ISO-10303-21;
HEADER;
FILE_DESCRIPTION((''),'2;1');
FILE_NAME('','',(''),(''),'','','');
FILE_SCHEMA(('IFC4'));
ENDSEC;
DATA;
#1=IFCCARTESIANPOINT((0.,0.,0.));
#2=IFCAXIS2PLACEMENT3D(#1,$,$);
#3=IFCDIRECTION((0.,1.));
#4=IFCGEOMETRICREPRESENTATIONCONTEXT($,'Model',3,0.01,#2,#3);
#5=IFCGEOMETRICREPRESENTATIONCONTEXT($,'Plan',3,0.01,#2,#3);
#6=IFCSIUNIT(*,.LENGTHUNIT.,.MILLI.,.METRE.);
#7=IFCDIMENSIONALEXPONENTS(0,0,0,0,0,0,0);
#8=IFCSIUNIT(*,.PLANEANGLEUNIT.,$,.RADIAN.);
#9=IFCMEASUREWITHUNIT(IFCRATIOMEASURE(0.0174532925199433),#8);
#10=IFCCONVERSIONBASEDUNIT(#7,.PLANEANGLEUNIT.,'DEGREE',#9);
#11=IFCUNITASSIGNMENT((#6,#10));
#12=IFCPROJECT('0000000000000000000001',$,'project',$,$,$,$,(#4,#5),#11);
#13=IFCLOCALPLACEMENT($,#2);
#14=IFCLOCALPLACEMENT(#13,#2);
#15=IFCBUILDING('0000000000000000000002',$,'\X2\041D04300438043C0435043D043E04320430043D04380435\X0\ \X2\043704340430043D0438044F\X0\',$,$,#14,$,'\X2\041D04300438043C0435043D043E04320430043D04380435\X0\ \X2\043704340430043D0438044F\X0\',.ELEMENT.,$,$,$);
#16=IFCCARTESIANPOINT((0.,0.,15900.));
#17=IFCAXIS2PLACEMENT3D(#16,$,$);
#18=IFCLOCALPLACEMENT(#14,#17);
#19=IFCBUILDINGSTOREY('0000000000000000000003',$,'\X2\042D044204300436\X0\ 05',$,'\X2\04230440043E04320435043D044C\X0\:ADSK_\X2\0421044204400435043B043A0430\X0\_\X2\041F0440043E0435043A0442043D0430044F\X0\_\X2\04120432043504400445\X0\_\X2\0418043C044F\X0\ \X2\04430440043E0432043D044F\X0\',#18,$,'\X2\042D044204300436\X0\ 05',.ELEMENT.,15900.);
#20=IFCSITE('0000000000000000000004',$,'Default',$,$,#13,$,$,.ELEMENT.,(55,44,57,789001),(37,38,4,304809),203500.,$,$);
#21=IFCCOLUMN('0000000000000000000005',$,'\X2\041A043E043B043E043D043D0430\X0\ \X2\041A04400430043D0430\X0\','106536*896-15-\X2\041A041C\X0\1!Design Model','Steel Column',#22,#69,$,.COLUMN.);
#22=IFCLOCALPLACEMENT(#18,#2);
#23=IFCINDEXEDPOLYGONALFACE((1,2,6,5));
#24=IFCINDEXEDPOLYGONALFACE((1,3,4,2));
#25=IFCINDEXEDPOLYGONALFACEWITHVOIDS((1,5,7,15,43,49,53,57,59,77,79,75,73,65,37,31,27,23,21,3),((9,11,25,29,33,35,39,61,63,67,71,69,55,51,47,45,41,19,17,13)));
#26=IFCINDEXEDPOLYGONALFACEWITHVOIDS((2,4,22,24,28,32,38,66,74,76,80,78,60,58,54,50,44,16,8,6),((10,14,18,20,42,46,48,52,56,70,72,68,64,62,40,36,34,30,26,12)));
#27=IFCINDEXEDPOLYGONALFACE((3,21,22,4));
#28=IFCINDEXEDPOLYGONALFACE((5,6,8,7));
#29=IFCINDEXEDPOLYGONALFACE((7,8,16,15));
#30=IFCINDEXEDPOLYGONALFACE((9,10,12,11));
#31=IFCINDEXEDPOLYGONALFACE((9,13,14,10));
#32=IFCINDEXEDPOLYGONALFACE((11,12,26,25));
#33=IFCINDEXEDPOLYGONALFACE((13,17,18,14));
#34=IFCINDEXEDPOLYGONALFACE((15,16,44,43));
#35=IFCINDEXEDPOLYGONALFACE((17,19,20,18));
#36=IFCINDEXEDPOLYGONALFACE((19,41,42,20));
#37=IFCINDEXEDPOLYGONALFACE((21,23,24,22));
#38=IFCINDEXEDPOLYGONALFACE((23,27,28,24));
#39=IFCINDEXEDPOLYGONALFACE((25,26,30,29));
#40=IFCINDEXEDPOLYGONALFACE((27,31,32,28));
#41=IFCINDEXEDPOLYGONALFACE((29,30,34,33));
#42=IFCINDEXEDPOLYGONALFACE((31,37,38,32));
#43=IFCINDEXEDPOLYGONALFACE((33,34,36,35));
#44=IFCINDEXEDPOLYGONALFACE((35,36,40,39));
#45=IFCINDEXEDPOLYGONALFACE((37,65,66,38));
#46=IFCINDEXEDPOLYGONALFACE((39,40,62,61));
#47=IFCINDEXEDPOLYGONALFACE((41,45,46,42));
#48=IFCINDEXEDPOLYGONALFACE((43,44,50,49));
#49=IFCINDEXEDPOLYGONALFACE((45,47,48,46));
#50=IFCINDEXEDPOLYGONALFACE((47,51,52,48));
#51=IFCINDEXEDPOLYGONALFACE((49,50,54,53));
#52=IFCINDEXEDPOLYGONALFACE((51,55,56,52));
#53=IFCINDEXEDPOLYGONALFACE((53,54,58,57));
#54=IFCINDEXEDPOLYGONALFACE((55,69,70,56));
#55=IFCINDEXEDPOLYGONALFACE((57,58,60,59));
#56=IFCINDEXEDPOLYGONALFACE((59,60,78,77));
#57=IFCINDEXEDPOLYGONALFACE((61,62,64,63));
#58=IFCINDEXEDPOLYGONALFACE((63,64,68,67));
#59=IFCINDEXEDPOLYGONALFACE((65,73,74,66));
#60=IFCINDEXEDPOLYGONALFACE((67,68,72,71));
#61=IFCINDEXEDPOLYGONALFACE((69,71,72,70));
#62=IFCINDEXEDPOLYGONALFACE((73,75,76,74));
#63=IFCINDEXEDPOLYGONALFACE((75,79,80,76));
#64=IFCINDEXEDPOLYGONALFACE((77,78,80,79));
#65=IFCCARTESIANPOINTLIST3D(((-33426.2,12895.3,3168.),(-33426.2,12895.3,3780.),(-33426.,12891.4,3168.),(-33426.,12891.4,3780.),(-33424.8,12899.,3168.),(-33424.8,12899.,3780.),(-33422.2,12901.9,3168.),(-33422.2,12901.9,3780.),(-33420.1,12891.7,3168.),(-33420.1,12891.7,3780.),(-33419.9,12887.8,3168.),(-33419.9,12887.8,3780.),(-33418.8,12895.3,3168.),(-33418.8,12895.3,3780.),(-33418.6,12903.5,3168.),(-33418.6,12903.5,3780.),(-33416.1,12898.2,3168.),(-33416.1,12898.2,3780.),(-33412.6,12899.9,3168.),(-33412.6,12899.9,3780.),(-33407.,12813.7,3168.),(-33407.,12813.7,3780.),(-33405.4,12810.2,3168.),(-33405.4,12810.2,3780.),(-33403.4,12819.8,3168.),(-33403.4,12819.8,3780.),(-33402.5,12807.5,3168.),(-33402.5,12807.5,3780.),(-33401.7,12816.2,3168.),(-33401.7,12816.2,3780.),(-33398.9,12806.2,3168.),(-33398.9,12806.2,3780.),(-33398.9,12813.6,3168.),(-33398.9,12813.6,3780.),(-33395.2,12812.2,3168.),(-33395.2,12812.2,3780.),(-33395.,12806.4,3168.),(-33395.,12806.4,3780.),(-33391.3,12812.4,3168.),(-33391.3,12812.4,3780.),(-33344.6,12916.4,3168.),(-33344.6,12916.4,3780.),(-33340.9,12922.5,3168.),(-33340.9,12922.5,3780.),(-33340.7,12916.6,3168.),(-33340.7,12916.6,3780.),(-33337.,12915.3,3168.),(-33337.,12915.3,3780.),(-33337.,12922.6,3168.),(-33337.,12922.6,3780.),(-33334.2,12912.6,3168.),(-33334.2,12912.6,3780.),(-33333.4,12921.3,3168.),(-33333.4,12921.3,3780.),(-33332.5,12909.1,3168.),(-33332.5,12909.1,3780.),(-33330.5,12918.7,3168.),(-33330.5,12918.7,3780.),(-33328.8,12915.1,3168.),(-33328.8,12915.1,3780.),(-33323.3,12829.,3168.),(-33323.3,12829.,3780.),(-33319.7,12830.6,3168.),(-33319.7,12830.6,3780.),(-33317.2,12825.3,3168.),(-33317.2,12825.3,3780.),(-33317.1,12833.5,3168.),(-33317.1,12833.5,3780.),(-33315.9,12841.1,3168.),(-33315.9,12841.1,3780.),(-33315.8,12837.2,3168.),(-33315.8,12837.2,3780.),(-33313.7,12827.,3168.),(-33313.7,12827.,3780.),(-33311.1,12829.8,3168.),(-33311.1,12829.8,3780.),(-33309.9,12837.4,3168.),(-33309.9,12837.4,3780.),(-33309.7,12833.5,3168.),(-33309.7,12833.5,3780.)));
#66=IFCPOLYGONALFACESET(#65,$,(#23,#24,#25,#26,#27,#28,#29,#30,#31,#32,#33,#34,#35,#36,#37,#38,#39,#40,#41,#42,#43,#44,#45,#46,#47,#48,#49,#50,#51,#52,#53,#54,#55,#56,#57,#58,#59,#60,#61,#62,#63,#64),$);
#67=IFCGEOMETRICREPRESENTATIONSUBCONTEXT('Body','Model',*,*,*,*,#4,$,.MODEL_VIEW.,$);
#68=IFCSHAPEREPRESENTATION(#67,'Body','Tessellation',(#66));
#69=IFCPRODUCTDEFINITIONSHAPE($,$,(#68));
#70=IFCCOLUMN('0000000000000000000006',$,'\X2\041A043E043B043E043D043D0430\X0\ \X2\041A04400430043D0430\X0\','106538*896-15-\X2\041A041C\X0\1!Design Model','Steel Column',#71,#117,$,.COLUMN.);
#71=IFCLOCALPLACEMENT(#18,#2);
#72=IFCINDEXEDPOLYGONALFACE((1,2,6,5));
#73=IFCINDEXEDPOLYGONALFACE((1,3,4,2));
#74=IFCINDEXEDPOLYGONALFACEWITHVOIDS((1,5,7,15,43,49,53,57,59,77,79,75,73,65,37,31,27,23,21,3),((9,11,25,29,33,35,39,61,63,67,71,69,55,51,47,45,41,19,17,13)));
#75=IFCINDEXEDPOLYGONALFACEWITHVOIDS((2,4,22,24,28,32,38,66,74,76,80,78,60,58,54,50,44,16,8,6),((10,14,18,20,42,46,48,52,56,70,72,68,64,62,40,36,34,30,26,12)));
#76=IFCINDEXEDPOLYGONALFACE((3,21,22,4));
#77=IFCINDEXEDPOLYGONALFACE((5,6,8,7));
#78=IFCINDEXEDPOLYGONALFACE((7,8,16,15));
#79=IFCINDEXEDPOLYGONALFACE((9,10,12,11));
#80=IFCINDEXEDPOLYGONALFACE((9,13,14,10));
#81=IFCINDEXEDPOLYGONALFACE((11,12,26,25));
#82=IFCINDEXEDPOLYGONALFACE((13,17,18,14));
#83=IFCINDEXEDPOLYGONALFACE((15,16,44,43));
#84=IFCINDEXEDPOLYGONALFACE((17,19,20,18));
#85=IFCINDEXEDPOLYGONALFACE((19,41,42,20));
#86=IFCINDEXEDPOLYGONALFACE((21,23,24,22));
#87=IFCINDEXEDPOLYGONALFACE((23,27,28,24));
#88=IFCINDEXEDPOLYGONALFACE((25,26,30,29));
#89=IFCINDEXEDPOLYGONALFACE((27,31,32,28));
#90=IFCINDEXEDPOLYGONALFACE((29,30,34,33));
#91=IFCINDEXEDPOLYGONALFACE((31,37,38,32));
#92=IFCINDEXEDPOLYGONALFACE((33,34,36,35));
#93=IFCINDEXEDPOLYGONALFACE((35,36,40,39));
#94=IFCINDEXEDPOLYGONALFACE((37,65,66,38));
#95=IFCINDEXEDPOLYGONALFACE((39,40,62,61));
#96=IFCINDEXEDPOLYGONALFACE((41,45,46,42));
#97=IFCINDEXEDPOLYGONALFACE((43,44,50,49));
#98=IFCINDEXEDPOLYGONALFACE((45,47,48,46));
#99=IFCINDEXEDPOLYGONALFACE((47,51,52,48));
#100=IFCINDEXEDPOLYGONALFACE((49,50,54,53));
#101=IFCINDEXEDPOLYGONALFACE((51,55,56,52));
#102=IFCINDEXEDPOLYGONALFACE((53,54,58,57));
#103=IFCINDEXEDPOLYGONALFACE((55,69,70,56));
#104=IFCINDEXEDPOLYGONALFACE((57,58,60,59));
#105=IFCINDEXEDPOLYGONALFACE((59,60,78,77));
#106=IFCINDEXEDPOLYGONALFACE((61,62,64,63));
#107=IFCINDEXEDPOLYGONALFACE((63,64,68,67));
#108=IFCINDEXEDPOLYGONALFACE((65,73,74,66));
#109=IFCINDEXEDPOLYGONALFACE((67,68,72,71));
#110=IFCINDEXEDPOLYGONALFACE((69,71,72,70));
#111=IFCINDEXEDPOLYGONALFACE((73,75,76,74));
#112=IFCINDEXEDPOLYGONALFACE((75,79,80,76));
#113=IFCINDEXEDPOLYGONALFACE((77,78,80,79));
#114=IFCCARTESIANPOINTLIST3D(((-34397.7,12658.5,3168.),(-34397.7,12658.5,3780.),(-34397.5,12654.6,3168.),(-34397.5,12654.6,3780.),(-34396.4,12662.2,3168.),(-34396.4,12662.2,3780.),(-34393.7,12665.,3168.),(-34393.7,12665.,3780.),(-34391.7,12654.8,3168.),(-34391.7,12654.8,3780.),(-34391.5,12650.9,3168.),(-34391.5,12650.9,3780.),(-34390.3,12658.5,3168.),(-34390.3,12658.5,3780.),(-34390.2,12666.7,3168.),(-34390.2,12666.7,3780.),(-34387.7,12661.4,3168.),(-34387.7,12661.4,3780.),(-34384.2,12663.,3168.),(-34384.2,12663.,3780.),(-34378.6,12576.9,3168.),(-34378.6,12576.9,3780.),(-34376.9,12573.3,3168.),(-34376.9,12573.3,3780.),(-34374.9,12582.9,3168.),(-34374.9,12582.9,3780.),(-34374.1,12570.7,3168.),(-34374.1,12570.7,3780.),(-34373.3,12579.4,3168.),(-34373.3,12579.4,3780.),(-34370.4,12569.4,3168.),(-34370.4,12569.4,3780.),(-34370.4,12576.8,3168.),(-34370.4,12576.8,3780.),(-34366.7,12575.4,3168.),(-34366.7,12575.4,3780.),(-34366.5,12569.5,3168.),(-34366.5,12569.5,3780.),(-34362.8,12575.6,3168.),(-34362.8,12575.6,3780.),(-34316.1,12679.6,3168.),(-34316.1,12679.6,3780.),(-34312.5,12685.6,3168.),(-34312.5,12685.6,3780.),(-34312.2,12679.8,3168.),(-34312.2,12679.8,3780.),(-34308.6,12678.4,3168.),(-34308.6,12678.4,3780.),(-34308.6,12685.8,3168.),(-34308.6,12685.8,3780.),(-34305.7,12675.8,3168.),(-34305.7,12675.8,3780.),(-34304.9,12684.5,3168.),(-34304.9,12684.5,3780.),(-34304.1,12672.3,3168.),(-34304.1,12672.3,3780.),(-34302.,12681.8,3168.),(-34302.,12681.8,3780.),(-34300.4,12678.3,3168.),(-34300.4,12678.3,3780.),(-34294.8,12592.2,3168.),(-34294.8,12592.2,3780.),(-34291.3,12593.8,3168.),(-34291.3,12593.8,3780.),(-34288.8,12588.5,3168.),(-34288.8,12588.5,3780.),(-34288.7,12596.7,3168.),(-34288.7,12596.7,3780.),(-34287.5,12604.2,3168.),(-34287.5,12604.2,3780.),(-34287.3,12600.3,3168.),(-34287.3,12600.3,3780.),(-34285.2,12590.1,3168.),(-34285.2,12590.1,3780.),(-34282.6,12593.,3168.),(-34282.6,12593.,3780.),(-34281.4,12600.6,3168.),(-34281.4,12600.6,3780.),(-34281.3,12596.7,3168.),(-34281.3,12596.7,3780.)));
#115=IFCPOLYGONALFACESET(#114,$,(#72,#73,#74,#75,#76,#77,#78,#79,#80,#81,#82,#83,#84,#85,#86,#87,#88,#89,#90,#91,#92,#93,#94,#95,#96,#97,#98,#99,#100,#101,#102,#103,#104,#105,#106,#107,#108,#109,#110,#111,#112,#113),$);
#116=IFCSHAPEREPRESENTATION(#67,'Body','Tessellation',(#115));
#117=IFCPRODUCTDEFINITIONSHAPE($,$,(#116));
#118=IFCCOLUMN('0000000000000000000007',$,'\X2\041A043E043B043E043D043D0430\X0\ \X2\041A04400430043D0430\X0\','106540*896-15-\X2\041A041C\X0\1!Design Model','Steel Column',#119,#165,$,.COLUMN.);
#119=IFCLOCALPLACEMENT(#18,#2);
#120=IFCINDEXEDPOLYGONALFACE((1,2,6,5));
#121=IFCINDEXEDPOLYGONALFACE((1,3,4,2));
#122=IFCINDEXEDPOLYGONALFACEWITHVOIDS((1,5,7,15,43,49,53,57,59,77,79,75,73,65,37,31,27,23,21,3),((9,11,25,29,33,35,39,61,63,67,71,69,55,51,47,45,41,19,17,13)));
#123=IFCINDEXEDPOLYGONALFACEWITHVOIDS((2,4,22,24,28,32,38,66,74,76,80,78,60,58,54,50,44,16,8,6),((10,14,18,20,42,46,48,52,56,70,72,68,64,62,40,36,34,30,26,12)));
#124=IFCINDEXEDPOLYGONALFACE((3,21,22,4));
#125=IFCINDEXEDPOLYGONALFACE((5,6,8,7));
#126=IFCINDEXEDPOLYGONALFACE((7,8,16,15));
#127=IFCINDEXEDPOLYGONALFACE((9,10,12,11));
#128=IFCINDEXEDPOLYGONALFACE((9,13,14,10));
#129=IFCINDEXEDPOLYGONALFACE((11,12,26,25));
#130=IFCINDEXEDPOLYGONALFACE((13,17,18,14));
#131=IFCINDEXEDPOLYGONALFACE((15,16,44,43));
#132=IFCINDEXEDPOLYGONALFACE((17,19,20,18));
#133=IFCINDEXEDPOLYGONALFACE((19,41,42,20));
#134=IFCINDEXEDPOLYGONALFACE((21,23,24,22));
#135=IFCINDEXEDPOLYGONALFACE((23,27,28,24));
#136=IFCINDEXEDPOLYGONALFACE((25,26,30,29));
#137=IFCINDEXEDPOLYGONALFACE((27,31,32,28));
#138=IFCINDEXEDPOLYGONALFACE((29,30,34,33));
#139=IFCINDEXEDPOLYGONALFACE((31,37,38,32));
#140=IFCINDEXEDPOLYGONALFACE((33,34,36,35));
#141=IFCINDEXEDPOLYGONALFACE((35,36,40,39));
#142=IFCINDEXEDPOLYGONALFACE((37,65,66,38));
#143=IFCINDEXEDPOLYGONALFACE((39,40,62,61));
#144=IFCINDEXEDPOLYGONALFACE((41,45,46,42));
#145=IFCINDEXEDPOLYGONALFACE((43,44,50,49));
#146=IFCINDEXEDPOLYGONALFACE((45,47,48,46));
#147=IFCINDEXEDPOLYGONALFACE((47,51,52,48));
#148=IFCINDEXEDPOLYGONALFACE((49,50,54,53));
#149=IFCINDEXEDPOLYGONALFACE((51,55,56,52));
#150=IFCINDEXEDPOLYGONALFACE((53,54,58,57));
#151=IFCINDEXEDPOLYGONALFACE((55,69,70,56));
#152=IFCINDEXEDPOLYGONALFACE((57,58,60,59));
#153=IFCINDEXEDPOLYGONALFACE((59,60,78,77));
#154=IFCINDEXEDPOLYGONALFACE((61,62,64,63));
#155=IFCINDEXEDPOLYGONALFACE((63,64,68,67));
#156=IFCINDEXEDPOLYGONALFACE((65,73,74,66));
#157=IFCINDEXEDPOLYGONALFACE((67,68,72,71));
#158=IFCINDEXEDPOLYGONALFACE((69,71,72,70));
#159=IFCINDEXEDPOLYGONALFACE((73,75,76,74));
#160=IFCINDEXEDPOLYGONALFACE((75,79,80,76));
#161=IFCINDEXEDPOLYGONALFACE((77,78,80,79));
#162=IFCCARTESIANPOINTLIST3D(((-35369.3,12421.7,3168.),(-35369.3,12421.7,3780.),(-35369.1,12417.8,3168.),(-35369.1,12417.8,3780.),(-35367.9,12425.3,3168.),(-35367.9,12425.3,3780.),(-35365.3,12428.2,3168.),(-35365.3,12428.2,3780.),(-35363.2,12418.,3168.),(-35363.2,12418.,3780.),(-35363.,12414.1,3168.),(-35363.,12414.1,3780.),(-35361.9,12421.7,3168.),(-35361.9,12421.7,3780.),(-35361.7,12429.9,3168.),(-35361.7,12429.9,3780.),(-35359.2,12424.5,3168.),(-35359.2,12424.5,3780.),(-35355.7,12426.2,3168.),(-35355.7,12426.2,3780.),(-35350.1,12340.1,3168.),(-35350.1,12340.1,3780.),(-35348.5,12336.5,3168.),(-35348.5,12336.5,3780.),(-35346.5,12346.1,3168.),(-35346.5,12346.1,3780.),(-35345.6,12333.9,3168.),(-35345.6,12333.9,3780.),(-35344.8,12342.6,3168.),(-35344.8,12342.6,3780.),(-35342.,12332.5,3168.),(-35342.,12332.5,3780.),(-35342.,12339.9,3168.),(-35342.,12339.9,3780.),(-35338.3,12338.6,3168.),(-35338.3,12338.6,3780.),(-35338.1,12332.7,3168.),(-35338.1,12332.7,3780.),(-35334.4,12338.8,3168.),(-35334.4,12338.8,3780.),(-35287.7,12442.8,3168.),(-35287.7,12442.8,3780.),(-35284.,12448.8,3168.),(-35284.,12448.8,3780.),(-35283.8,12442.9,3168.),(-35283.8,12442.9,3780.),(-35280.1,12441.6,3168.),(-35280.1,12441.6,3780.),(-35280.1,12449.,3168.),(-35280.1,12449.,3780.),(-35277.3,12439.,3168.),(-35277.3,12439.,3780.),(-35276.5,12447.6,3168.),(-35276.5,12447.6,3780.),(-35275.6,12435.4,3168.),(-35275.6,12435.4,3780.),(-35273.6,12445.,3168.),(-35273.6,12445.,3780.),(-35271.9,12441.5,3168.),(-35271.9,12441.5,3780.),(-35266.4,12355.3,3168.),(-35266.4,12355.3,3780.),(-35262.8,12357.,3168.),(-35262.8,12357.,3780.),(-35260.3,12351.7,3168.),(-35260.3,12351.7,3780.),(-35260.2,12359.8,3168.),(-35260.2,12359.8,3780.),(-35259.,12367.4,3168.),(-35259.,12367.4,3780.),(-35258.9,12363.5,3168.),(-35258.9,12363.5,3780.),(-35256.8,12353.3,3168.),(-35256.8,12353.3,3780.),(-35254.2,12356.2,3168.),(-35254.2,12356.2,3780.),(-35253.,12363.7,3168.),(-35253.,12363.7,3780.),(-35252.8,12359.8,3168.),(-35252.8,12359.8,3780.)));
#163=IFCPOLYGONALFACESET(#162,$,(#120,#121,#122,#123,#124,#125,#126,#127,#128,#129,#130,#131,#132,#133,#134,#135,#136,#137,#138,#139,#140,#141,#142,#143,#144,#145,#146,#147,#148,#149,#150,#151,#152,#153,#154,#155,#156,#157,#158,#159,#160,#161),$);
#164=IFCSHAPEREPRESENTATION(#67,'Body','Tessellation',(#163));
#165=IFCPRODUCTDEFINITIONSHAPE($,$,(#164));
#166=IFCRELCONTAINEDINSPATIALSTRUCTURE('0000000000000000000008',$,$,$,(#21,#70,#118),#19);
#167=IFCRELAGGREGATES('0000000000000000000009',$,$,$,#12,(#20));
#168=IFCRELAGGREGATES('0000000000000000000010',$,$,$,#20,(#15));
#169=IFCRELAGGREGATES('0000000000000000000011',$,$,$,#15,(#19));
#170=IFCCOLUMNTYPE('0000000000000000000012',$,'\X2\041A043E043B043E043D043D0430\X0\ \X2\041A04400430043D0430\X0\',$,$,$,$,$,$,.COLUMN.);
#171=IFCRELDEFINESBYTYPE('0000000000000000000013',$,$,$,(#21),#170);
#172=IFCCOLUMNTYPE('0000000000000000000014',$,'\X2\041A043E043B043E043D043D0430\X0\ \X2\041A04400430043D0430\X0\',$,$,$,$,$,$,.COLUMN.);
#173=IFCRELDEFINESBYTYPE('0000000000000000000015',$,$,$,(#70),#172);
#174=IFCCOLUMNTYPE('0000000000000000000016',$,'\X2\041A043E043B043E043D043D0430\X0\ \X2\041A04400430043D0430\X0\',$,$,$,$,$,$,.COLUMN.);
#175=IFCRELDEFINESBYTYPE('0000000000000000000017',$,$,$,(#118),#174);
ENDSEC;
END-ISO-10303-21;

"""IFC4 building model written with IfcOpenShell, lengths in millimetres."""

from ifc_helpers import new_model, entity, si_unit, converted_unit, direction, frame, origin, place, context, subcontext, project, spatial, indexed_curve, outline, extrude, type_object, element, save


model = new_model("IFC4")

# Units and contexts
model_context = context("Model", 3, precision=0.01, world=origin(), true_north=direction((0.0, 1.0)))
plan_context = context("Plan", 3, precision=0.01, world=origin(), true_north=direction((0.0, 1.0)))
body_context = subcontext(model_context, "Body", "Model", "MODEL_VIEW")
ifc_project = project(units=[si_unit("LENGTHUNIT", "METRE", prefix="MILLI"), converted_unit("PLANEANGLEUNIT", "DEGREE", entity("IfcRatioMeasure", 0.0174532925199433), si_unit("PLANEANGLEUNIT", "RADIAN"), dimensions=[0, 0, 0, 0, 0, 0, 0])], contexts=[model_context, plan_context])

# Site, building, storey
site_placement = place(None, origin())
site = spatial("IfcSite", under=ifc_project, at=site_placement, Name="Default", CompositionType="ELEMENT", RefLatitude=(55, 44, 57, 789001), RefLongitude=(37, 38, 4, 304809), RefElevation=203500.0)
building_placement = place(site_placement, origin())
building = spatial("IfcBuilding", under=site, at=building_placement, Name="Наименование здания", LongName="Наименование здания", CompositionType="ELEMENT")
storey_placement = place(building_placement, frame((0.0, 0.0, 15900.0)))
storey = spatial("IfcBuildingStorey", under=building, at=storey_placement, Name="Этаж 05", ObjectType="Уровень:ADSK_Стрелка_Проектная_Вверх_Имя уровня", LongName="Этаж 05", CompositionType="ELEMENT", Elevation=15900.0)

# Columns
placement = place(storey_placement, origin())
column_type_1 = type_object("IfcColumnType", Name="Колонна Крана", PredefinedType="COLUMN")
element("IfcColumn", 1, at=placement, inside=storey, type_object=column_type_1, Name="Колонна Крана", Description="106536*896-15-КМ1!Design Model", ObjectType="Steel Column", PredefinedType="COLUMN", context=body_context, shape_type="SweptSolid", body=[
    extrude(outline(indexed_curve([(29.5, -56.8), (33.4, -56.8), (37.0, -55.3), (39.7, -52.6), (41.2, -49.0), (56.8, 29.5), (56.8, 33.4), (55.3, 37.0), (52.6, 39.7), (49.0, 41.2), (-29.5, 56.8), (-33.4, 56.8), (-37.0, 55.3), (-39.7, 52.6), (-41.2, 49.0), (-56.8, -29.5), (-56.8, -33.4), (-55.3, -37.0), (-52.6, -39.7), (-49.0, -41.2), (29.5, -56.8)], self_intersect=False), holes=[indexed_curve([(-43.1, -37.3), (-46.7, -35.8), (-49.5, -33.1), (-51.0, -29.5), (-51.0, -25.5), (-37.3, 43.1), (-35.8, 46.7), (-33.1, 49.5), (-29.5, 51.0), (-25.5, 51.0), (43.1, 37.3), (46.7, 35.8), (49.5, 33.1), (51.0, 29.5), (51.0, 25.5), (37.3, -43.1), (35.8, -46.7), (33.1, -49.5), (29.5, -51.0), (25.5, -51.0), (-43.1, -37.3)], self_intersect=False)]), frame((-33367.9, 12864.4, 3168.0), z_axis=(0.0, 0.0, 1.0), x_axis=(0.906681, 0.421816, 0.0)), (0.0, 0.0, 1.0), 612.0),
])
column_type_2 = type_object("IfcColumnType", Name="Колонна Крана", PredefinedType="COLUMN")
element("IfcColumn", 2, at=placement, inside=storey, type_object=column_type_2, Name="Колонна Крана", Description="106538*896-15-КМ1!Design Model", ObjectType="Steel Column", PredefinedType="COLUMN", context=body_context, shape_type="SweptSolid", body=[
    extrude(outline(indexed_curve([(29.5, -56.8), (33.4, -56.8), (37.0, -55.3), (39.7, -52.6), (41.2, -49.0), (56.8, 29.5), (56.8, 33.4), (55.3, 37.0), (52.6, 39.7), (49.0, 41.2), (-29.5, 56.8), (-33.4, 56.8), (-37.0, 55.3), (-39.7, 52.6), (-41.2, 49.0), (-56.8, -29.5), (-56.8, -33.4), (-55.3, -37.0), (-52.6, -39.7), (-49.0, -41.2), (29.5, -56.8)], self_intersect=False), holes=[indexed_curve([(-43.1, -37.3), (-46.7, -35.8), (-49.5, -33.1), (-51.0, -29.5), (-51.0, -25.5), (-37.3, 43.1), (-35.8, 46.7), (-33.1, 49.5), (-29.5, 51.0), (-25.5, 51.0), (43.1, 37.3), (46.7, 35.8), (49.5, 33.1), (51.0, 29.5), (51.0, 25.5), (37.3, -43.1), (35.8, -46.7), (33.1, -49.5), (29.5, -51.0), (25.5, -51.0), (-43.1, -37.3)], self_intersect=False)]), frame((-34339.5, 12627.6, 3168.0), z_axis=(0.0, 0.0, 1.0), x_axis=(0.906681, 0.421816, 0.0)), (0.0, 0.0, 1.0), 612.0),
])
column_type_3 = type_object("IfcColumnType", Name="Колонна Крана", PredefinedType="COLUMN")
element("IfcColumn", 3, at=placement, inside=storey, type_object=column_type_3, Name="Колонна Крана", Description="106540*896-15-КМ1!Design Model", ObjectType="Steel Column", PredefinedType="COLUMN", context=body_context, shape_type="SweptSolid", body=[
    extrude(outline(indexed_curve([(29.5, -56.8), (33.4, -56.8), (37.0, -55.3), (39.7, -52.6), (41.2, -49.0), (56.8, 29.5), (56.8, 33.4), (55.3, 37.0), (52.6, 39.7), (49.0, 41.2), (-29.5, 56.8), (-33.4, 56.8), (-37.0, 55.3), (-39.7, 52.6), (-41.2, 49.0), (-56.8, -29.5), (-56.8, -33.4), (-55.3, -37.0), (-52.6, -39.7), (-49.0, -41.2), (29.5, -56.8)], self_intersect=False), holes=[indexed_curve([(-43.1, -37.3), (-46.7, -35.8), (-49.5, -33.1), (-51.0, -29.5), (-51.0, -25.5), (-37.3, 43.1), (-35.8, 46.7), (-33.1, 49.5), (-29.5, 51.0), (-25.5, 51.0), (43.1, 37.3), (46.7, 35.8), (49.5, 33.1), (51.0, 29.5), (51.0, 25.5), (37.3, -43.1), (35.8, -46.7), (33.1, -49.5), (29.5, -51.0), (25.5, -51.0), (-43.1, -37.3)], self_intersect=False)]), frame((-35311.0, 12390.8, 3168.0), z_axis=(0.0, 0.0, 1.0), x_axis=(0.906681, 0.421816, 0.0)), (0.0, 0.0, 1.0), 612.0),
])

save(model, "model.ifc")
